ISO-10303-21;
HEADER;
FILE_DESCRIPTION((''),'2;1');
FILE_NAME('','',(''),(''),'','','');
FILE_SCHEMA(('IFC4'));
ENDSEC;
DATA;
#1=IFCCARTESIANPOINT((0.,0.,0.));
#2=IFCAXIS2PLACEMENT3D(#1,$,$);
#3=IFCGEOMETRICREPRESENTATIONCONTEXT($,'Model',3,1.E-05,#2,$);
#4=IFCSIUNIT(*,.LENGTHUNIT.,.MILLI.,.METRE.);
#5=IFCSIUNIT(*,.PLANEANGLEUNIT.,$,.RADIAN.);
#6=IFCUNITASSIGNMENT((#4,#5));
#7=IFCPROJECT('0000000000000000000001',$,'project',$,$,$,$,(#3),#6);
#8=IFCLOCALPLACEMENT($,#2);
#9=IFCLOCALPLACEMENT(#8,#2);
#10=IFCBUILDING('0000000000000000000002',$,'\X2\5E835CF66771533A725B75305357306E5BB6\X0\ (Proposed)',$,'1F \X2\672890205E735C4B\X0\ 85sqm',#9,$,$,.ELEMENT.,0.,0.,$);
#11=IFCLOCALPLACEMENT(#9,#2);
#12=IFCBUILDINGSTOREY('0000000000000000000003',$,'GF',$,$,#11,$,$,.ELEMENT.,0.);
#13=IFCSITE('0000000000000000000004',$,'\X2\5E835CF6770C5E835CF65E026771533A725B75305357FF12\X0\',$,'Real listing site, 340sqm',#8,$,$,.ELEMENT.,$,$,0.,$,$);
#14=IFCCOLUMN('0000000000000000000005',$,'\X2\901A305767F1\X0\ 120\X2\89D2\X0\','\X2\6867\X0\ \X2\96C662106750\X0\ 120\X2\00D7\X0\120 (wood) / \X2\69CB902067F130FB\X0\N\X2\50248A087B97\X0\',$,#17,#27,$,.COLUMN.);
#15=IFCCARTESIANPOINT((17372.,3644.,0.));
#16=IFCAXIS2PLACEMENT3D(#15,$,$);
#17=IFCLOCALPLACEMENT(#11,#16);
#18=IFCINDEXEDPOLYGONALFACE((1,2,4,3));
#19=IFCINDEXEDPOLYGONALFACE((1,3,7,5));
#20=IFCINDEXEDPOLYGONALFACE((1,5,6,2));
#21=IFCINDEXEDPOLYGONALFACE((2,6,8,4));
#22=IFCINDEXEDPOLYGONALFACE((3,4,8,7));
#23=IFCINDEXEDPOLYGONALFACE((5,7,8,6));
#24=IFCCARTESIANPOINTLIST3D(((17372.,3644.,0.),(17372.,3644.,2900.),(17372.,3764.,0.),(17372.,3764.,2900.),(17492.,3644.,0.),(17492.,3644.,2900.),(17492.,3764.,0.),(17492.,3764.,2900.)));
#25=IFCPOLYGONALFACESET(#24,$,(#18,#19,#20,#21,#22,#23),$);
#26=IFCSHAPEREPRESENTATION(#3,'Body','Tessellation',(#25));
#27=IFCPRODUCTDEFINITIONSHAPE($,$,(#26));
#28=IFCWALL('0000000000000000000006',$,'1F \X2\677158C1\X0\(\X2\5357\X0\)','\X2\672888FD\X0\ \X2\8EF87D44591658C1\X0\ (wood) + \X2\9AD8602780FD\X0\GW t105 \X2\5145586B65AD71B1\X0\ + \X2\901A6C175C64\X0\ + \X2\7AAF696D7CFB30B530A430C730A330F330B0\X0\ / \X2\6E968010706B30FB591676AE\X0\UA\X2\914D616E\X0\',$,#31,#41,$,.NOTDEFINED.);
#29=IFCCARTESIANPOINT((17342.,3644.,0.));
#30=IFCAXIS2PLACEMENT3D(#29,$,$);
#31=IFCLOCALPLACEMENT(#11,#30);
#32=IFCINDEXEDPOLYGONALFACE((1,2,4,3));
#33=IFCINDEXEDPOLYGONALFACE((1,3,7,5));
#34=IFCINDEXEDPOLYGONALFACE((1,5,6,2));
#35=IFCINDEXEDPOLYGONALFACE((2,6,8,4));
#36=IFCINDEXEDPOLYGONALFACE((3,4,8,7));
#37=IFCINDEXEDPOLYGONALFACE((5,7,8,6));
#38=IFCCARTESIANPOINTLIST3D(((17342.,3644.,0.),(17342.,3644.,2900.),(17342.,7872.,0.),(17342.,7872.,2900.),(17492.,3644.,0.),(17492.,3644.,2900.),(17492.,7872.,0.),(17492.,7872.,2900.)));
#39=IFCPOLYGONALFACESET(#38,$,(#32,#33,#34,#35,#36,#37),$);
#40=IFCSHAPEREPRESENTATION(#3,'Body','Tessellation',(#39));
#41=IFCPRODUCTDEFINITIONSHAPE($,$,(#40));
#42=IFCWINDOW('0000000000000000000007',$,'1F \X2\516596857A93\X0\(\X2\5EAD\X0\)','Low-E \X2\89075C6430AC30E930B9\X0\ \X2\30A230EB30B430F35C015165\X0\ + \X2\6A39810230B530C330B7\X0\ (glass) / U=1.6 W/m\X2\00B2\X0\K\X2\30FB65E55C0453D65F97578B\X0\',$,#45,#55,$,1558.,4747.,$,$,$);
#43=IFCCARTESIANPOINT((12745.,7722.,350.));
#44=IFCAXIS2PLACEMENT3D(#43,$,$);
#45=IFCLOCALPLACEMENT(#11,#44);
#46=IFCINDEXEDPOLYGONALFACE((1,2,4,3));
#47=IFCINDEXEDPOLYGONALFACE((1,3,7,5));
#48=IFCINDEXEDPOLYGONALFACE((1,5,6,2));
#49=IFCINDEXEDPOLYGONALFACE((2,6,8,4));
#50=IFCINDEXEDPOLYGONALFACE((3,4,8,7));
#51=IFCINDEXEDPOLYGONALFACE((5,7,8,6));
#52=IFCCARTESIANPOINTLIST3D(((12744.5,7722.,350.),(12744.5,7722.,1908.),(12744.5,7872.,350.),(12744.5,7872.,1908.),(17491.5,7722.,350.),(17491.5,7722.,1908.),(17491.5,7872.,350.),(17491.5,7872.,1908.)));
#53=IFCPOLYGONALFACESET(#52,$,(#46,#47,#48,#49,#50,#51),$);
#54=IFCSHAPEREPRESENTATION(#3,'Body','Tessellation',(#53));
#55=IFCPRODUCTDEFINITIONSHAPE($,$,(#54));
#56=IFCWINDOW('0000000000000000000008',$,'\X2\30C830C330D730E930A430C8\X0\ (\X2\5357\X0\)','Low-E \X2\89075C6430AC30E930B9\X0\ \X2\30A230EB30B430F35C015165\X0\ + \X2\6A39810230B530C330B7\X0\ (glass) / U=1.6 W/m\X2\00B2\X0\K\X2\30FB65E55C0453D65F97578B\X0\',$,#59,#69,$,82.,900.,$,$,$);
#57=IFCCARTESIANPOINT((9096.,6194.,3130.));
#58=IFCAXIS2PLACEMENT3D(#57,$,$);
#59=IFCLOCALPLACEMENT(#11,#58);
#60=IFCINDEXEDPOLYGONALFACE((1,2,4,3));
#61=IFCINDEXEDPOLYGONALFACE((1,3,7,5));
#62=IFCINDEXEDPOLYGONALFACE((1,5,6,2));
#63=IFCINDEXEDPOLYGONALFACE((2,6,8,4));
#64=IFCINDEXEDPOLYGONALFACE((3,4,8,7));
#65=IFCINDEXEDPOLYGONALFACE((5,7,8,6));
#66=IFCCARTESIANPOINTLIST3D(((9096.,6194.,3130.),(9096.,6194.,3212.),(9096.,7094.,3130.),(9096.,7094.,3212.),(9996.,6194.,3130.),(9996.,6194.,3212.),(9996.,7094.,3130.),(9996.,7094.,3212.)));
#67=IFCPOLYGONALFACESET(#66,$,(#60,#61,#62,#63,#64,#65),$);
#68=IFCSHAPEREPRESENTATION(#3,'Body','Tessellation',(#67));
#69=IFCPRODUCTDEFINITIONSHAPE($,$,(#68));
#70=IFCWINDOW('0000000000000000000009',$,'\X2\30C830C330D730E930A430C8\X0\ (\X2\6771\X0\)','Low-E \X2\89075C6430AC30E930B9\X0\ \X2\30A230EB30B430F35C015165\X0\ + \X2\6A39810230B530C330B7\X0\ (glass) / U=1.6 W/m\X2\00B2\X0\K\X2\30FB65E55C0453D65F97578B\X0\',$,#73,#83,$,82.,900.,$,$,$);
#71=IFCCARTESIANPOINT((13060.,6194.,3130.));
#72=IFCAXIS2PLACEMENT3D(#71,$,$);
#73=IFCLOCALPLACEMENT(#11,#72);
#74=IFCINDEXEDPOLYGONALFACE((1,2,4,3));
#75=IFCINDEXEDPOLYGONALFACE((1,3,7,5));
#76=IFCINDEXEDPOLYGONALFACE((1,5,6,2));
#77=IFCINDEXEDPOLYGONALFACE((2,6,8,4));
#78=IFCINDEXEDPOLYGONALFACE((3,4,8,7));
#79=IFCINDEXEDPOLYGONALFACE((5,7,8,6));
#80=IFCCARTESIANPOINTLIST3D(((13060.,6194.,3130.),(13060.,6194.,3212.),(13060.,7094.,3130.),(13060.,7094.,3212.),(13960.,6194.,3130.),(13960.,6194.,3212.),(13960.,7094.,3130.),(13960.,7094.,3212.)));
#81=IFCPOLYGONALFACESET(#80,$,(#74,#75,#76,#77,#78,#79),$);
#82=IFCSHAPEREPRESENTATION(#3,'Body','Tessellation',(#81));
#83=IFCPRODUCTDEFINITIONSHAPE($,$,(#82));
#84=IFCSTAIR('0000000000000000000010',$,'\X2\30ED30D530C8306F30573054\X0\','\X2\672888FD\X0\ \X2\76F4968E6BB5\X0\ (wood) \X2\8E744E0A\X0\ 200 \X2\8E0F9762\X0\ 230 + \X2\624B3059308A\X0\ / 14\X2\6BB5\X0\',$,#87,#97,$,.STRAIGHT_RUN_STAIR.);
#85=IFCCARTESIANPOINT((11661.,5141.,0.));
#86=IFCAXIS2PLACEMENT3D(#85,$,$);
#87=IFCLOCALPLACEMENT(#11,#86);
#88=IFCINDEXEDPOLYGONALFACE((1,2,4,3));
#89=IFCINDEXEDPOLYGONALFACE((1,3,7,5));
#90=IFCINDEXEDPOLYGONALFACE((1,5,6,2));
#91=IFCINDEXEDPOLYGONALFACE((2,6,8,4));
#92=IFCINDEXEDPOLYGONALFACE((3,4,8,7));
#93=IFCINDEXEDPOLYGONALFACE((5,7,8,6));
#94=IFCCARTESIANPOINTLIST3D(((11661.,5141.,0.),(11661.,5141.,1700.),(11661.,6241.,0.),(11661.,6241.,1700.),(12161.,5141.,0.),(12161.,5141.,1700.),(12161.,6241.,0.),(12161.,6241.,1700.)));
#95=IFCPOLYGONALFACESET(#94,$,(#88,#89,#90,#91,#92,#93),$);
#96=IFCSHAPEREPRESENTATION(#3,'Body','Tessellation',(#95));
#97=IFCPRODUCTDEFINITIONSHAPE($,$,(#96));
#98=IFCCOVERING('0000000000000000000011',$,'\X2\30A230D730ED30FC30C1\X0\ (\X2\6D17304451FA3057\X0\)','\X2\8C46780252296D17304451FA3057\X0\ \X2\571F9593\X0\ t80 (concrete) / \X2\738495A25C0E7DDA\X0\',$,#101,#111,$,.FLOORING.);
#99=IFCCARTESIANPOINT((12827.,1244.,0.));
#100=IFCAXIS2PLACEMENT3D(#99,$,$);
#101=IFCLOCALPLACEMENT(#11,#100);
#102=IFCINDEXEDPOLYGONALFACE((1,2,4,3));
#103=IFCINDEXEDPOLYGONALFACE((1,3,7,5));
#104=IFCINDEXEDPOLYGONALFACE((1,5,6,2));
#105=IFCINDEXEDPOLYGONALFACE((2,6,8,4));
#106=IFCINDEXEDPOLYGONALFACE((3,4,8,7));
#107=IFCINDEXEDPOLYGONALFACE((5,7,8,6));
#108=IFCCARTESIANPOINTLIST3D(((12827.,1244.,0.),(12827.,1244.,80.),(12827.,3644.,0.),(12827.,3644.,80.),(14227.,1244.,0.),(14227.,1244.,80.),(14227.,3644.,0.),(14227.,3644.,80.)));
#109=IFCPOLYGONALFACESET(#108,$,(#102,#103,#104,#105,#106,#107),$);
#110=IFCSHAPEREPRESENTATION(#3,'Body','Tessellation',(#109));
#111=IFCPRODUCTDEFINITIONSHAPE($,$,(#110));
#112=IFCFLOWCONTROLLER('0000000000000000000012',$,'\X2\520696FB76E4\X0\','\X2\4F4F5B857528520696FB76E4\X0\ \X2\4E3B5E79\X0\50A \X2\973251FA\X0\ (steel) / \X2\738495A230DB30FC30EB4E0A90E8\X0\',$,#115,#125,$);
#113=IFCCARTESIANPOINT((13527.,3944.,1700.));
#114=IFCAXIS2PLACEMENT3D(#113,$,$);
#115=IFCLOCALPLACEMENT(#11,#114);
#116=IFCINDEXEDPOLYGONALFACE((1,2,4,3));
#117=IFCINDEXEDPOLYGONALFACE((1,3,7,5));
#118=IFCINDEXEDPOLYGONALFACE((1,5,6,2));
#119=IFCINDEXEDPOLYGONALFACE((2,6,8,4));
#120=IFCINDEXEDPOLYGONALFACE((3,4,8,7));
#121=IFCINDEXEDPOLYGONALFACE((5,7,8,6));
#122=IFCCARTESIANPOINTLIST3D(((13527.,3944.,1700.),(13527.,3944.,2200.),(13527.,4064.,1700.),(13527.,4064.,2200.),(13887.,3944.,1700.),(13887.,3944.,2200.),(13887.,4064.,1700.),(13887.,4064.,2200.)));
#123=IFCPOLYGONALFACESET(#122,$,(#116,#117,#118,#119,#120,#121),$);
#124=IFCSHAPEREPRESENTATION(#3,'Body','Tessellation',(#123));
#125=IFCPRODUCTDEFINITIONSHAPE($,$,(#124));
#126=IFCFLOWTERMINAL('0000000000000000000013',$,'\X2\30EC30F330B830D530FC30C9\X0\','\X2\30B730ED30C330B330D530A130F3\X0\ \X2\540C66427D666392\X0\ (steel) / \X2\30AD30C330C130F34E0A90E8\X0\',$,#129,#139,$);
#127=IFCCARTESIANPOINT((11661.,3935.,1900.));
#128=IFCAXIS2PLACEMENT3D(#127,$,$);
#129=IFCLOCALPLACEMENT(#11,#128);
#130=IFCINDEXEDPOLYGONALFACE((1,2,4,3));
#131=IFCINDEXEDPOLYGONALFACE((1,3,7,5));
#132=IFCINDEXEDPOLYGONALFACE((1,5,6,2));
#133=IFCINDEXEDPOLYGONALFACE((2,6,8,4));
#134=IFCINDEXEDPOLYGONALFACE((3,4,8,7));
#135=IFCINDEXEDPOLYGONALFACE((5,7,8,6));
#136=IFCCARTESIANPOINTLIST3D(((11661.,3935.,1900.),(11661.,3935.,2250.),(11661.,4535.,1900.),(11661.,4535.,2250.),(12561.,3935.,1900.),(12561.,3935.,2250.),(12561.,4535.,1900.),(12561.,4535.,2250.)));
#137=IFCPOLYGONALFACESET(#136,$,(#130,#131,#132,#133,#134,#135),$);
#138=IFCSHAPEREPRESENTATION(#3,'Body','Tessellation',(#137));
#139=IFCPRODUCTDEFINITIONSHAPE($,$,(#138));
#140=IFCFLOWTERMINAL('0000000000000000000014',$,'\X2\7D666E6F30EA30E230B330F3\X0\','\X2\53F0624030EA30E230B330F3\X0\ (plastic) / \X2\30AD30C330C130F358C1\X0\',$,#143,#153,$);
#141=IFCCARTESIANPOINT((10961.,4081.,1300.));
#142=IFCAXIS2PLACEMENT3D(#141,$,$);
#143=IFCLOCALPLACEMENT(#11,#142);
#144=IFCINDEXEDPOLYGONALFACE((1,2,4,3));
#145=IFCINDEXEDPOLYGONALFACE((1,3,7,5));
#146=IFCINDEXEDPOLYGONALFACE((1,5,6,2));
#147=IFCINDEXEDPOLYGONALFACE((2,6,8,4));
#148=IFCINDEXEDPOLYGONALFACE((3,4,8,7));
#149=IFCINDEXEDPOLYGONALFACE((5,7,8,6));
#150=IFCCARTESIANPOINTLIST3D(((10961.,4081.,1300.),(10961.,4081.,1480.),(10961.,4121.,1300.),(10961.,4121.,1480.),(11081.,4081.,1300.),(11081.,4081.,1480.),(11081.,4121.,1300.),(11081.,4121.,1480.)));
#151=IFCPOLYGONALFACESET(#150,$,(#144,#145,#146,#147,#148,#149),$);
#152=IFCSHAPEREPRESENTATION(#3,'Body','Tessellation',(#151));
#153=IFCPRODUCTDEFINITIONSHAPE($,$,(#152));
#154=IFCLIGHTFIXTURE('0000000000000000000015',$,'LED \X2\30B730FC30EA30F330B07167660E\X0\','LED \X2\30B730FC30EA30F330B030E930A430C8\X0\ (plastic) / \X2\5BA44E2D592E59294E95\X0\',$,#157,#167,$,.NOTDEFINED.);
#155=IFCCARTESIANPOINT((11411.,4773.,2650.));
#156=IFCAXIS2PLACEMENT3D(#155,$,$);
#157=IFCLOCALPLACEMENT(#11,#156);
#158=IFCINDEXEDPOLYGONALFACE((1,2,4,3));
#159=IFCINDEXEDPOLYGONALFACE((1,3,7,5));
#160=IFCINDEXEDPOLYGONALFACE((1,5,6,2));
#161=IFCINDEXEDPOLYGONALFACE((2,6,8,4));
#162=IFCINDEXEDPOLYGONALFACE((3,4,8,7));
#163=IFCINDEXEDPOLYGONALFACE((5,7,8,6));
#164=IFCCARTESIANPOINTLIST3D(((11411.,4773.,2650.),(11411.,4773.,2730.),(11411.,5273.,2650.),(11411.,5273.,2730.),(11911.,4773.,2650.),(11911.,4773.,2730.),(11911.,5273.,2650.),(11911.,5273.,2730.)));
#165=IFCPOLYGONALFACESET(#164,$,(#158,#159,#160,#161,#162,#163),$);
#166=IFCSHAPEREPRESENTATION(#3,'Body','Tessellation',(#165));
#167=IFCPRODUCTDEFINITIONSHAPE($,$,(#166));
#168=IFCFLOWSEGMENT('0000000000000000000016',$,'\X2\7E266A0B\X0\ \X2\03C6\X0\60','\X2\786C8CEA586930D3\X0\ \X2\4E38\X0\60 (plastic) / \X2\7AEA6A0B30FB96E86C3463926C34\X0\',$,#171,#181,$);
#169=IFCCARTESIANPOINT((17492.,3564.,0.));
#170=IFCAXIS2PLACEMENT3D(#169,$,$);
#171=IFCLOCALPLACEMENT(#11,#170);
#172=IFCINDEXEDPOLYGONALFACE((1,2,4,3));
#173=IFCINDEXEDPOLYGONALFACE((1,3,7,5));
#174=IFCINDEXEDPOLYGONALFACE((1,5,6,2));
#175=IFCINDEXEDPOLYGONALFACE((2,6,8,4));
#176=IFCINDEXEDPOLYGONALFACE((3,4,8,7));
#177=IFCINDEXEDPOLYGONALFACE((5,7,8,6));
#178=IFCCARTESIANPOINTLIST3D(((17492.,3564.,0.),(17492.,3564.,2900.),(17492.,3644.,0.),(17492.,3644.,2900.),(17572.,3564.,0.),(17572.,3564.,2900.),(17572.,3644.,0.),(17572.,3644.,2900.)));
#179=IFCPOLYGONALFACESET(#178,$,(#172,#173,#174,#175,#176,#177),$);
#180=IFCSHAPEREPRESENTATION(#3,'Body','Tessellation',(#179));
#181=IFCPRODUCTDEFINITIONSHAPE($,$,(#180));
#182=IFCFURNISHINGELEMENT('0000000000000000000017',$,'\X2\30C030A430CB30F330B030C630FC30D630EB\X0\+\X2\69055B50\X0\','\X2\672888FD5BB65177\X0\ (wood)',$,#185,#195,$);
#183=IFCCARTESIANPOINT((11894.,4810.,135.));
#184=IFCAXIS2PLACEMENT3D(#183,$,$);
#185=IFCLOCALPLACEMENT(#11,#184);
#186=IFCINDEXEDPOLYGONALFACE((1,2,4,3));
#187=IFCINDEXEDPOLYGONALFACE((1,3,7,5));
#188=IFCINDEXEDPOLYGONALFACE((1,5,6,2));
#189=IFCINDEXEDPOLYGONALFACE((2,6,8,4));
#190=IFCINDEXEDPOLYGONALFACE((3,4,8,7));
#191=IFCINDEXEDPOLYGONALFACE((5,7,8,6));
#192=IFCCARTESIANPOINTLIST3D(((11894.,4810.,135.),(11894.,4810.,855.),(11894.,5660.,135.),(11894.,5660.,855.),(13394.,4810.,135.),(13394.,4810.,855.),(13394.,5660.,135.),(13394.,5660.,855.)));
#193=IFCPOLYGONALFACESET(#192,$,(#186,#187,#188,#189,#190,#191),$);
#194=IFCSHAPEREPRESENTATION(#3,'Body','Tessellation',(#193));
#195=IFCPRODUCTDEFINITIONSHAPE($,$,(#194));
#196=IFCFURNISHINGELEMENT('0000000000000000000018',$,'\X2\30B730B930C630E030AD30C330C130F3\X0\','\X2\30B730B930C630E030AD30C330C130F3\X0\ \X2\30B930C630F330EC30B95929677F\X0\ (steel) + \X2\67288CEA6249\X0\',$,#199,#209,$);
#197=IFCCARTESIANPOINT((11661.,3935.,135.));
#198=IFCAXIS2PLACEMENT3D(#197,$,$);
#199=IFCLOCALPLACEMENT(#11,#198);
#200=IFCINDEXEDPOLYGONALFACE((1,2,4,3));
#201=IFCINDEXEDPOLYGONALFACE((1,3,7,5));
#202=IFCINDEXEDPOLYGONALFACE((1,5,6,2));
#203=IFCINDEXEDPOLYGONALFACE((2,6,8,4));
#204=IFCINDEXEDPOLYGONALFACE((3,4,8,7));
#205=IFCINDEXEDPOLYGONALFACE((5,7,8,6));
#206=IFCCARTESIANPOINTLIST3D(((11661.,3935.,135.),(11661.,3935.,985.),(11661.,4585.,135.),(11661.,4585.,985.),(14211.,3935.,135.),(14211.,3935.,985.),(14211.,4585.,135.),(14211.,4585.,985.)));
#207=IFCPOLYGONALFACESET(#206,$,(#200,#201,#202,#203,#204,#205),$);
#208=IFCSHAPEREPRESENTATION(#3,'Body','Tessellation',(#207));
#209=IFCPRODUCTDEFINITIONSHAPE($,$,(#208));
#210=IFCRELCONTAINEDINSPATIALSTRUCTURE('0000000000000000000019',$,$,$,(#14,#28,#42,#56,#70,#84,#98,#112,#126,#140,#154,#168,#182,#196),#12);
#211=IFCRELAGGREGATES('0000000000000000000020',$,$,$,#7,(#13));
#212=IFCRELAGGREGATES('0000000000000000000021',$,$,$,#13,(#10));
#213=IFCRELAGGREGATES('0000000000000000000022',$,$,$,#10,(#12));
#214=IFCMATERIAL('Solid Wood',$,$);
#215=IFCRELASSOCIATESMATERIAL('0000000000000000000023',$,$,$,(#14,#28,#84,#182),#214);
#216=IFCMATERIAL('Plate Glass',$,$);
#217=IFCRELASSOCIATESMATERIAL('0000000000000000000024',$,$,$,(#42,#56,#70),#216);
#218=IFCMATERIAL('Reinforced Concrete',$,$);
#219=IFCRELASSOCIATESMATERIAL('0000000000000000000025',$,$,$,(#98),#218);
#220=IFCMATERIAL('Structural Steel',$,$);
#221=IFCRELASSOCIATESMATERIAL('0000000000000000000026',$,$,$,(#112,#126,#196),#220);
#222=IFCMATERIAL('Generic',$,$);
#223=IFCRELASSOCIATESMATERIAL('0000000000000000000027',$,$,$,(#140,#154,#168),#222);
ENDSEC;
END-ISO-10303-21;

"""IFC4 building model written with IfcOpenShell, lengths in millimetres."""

from ifc_helpers import new_model, si_unit, frame, frame_2d, origin, place, context, project, spatial, rectangle, extrude, material, element, fill, save


model = new_model("IFC4")

# Units and contexts
model_context = context("Model", 3, precision=1e-05, world=origin())
ifc_project = project(units=[si_unit("LENGTHUNIT", "METRE", prefix="MILLI"), si_unit("PLANEANGLEUNIT", "RADIAN")], contexts=[model_context])

# Site, building, storey
site_placement = place(None, origin())
site = spatial("IfcSite", under=ifc_project, at=site_placement, Name="広島県広島市東区牛田南２", ObjectType="Real listing site, 340sqm", CompositionType="ELEMENT", RefElevation=0.0)
building_placement = place(site_placement, origin())
building = spatial("IfcBuilding", under=site, at=building_placement, Name="広島東区牛田南の家 (Proposed)", ObjectType="1F 木造平屋 85sqm", CompositionType="ELEMENT", ElevationOfRefHeight=0.0, ElevationOfTerrain=0.0)
storey_placement = place(building_placement, origin())
storey = spatial("IfcBuildingStorey", under=building, at=storey_placement, Name="GF", CompositionType="ELEMENT", Elevation=0.0)

# Column
ifc_material_1 = material(Name="Solid Wood")
column_1_placement = place(storey_placement, frame((17372.0, 3644.0, 0.0)))
element("IfcColumn", 1, at=column_1_placement, inside=storey, material=ifc_material_1, Name="通し柱 120角", Description="桧 集成材 120×120 (wood) / 構造柱・N値計算", PredefinedType="COLUMN", context=model_context, shape_type="SweptSolid", body=[
    extrude(rectangle(XDim=120.0, YDim=120.0, at=frame_2d((60.0, 60.0))), frame((17372.0, 3644.0, 0.0)), (0.0, 0.0, 1.0), 2900.0),
])

# Wall, opening, window
wall_1_placement = place(storey_placement, frame((17342.0, 3644.0, 0.0)))
wall_1 = element("IfcWall", 2, at=wall_1_placement, inside=storey, material=ifc_material_1, Name="1F 東壁(南)", Description="木製 軸組外壁 (wood) + 高性能GW t105 充填断熱 + 通気層 + 窯業系サイディング / 準耐火・外皮UA配慮", PredefinedType="NOTDEFINED", context=model_context, shape_type="SweptSolid", body=[
    extrude(rectangle(XDim=150.0, YDim=4228.0, at=frame_2d((75.0, 2114.0))), frame((17342.0, 3644.0, 0.0)), (0.0, 0.0, 1.0), 2900.0),
])
opening_1_placement = place(storey_placement, frame((12745.0, 7722.0, 350.0)))
opening_1 = element("IfcOpeningElement", 3, at=opening_1_placement, cuts=wall_1, PredefinedType="NOTDEFINED", context=model_context, shape_type="SweptSolid", body=[
    extrude(rectangle(XDim=4747.0, YDim=150.0, at=frame_2d((2373.0, 75.0))), frame((12745.0, 7722.0, 350.0)), (0.0, 0.0, 1.0), 1558.0),
])
ifc_material_2 = material(Name="Plate Glass")
window_1_placement = place(storey_placement, frame((12745.0, 7722.0, 350.0)))
window_1 = element("IfcWindow", 4, at=window_1_placement, inside=storey, material=ifc_material_2, Name="1F 入隅窓(庭)", Description="Low-E 複層ガラス アルゴン封入 + 樹脂サッシ (glass) / U=1.6 W/m²K・日射取得型", OverallHeight=1558.0, OverallWidth=4747.0, context=model_context, shape_type="SweptSolid", body=[
    extrude(rectangle(XDim=4747.0, YDim=150.0, at=frame_2d((2373.0, 75.0))), frame((12745.0, 7722.0, 350.0)), (0.0, 0.0, 1.0), 1558.0),
])
fill(opening_1, window_1)

# Windows
window_2_placement = place(storey_placement, frame((9096.0, 6194.0, 3130.0)))
element("IfcWindow", 5, at=window_2_placement, inside=storey, material=ifc_material_2, Name="トップライト (南)", Description="Low-E 複層ガラス アルゴン封入 + 樹脂サッシ (glass) / U=1.6 W/m²K・日射取得型", OverallHeight=82.0, OverallWidth=900.0, context=model_context, shape_type="SweptSolid", body=[
    extrude(rectangle(XDim=900.0, YDim=900.0, at=frame_2d((450.0, 450.0))), frame((9096.0, 6194.0, 3130.0)), (0.0, 0.0, 1.0), 82.0),
])
window_3_placement = place(storey_placement, frame((13060.0, 6194.0, 3130.0)))
element("IfcWindow", 6, at=window_3_placement, inside=storey, material=ifc_material_2, Name="トップライト (東)", Description="Low-E 複層ガラス アルゴン封入 + 樹脂サッシ (glass) / U=1.6 W/m²K・日射取得型", OverallHeight=82.0, OverallWidth=900.0, context=model_context, shape_type="SweptSolid", body=[
    extrude(rectangle(XDim=900.0, YDim=900.0, at=frame_2d((450.0, 450.0))), frame((13060.0, 6194.0, 3130.0)), (0.0, 0.0, 1.0), 82.0),
])

# Stair
stair_placement = place(storey_placement, frame((11661.0, 5141.0, 0.0)))
element("IfcStair", 7, at=stair_placement, inside=storey, material=ifc_material_1, Name="ロフトはしご", Description="木製 直階段 (wood) 蹴上 200 踏面 230 + 手すり / 14段", PredefinedType="STRAIGHT_RUN_STAIR", context=model_context, shape_type="SweptSolid", body=[
    extrude(rectangle(XDim=500.0, YDim=1100.0, at=frame_2d((250.0, 550.0))), frame((11661.0, 5141.0, 0.0)), (0.0, 0.0, 1.0), 1700.0),
])

# Covering
ifc_material_3 = material(Name="Reinforced Concrete")
covering_placement = place(storey_placement, frame((12827.0, 1244.0, 0.0)))
element("IfcCovering", 8, at=covering_placement, inside=storey, material=ifc_material_3, Name="アプローチ (洗い出し)", Description="豆砂利洗い出し 土間 t80 (concrete) / 玄関導線", PredefinedType="FLOORING", context=model_context, shape_type="SweptSolid", body=[
    extrude(rectangle(XDim=1400.0, YDim=2400.0, at=frame_2d((700.0, 1200.0))), frame((12827.0, 1244.0, 0.0)), (0.0, 0.0, 1.0), 80.0),
])

# Flow controller
ifc_material_4 = material(Name="Structural Steel")
flow_controller_placement = place(storey_placement, frame((13527.0, 3944.0, 1700.0)))
element("IfcFlowController", 9, at=flow_controller_placement, inside=storey, material=ifc_material_4, Name="分電盤", Description="住宅用分電盤 主幹50A 露出 (steel) / 玄関ホール上部", context=model_context, shape_type="SweptSolid", body=[
    extrude(rectangle(XDim=360.0, YDim=120.0, at=frame_2d((180.0, 60.0))), frame((13527.0, 3944.0, 1700.0)), (0.0, 0.0, 1.0), 500.0),
])

# Flow terminals
flow_terminal_1_placement = place(storey_placement, frame((11661.0, 3935.0, 1900.0)))
element("IfcFlowTerminal", 10, at=flow_terminal_1_placement, inside=storey, material=ifc_material_4, Name="レンジフード", Description="シロッコファン 同時給排 (steel) / キッチン上部", context=model_context, shape_type="SweptSolid", body=[
    extrude(rectangle(XDim=900.0, YDim=600.0, at=frame_2d((450.0, 300.0))), frame((11661.0, 3935.0, 1900.0)), (0.0, 0.0, 1.0), 350.0),
])
ifc_material_5 = material(Name="Generic")
flow_terminal_2_placement = place(storey_placement, frame((10961.0, 4081.0, 1300.0)))
element("IfcFlowTerminal", 11, at=flow_terminal_2_placement, inside=storey, material=ifc_material_5, Name="給湯リモコン", Description="台所リモコン (plastic) / キッチン壁", context=model_context, shape_type="SweptSolid", body=[
    extrude(rectangle(XDim=120.0, YDim=40.0, at=frame_2d((60.0, 20.0))), frame((10961.0, 4081.0, 1300.0)), (0.0, 0.0, 1.0), 180.0),
])

# Light fixture
light_fixture_placement = place(storey_placement, frame((11411.0, 4773.0, 2650.0)))
element("IfcLightFixture", 12, at=light_fixture_placement, inside=storey, material=ifc_material_5, Name="LED シーリング照明", Description="LED シーリングライト (plastic) / 室中央天井", PredefinedType="NOTDEFINED", context=model_context, shape_type="SweptSolid", body=[
    extrude(rectangle(XDim=500.0, YDim=500.0, at=frame_2d((250.0, 250.0))), frame((11411.0, 4773.0, 2650.0)), (0.0, 0.0, 1.0), 80.0),
])

# Flow segment
flow_segment_placement = place(storey_placement, frame((17492.0, 3564.0, 0.0)))
element("IfcFlowSegment", 13, at=flow_segment_placement, inside=storey, material=ifc_material_5, Name="縦樋 φ60", Description="硬質塩ビ 丸60 (plastic) / 竪樋・雨水排水", context=model_context, shape_type="SweptSolid", body=[
    extrude(rectangle(XDim=80.0, YDim=80.0, at=frame_2d((40.0, 40.0))), frame((17492.0, 3564.0, 0.0)), (0.0, 0.0, 1.0), 2900.0),
])

# Furnishing elements
furnishing_1_placement = place(storey_placement, frame((11894.0, 4810.0, 135.0)))
element("IfcFurnishingElement", 14, at=furnishing_1_placement, inside=storey, material=ifc_material_1, Name="ダイニングテーブル+椅子", Description="木製家具 (wood)", context=model_context, shape_type="SweptSolid", body=[
    extrude(rectangle(XDim=1500.0, YDim=850.0, at=frame_2d((750.0, 425.0))), frame((11894.0, 4810.0, 135.0)), (0.0, 0.0, 1.0), 720.0),
])
furnishing_2_placement = place(storey_placement, frame((11661.0, 3935.0, 135.0)))
element("IfcFurnishingElement", 15, at=furnishing_2_placement, inside=storey, material=ifc_material_4, Name="システムキッチン", Description="システムキッチン ステンレス天板 (steel) + 木質扉", context=model_context, shape_type="SweptSolid", body=[
    extrude(rectangle(XDim=2550.0, YDim=650.0, at=frame_2d((1275.0, 325.0))), frame((11661.0, 3935.0, 135.0)), (0.0, 0.0, 1.0), 850.0),
])

save(model, "model.ifc")
